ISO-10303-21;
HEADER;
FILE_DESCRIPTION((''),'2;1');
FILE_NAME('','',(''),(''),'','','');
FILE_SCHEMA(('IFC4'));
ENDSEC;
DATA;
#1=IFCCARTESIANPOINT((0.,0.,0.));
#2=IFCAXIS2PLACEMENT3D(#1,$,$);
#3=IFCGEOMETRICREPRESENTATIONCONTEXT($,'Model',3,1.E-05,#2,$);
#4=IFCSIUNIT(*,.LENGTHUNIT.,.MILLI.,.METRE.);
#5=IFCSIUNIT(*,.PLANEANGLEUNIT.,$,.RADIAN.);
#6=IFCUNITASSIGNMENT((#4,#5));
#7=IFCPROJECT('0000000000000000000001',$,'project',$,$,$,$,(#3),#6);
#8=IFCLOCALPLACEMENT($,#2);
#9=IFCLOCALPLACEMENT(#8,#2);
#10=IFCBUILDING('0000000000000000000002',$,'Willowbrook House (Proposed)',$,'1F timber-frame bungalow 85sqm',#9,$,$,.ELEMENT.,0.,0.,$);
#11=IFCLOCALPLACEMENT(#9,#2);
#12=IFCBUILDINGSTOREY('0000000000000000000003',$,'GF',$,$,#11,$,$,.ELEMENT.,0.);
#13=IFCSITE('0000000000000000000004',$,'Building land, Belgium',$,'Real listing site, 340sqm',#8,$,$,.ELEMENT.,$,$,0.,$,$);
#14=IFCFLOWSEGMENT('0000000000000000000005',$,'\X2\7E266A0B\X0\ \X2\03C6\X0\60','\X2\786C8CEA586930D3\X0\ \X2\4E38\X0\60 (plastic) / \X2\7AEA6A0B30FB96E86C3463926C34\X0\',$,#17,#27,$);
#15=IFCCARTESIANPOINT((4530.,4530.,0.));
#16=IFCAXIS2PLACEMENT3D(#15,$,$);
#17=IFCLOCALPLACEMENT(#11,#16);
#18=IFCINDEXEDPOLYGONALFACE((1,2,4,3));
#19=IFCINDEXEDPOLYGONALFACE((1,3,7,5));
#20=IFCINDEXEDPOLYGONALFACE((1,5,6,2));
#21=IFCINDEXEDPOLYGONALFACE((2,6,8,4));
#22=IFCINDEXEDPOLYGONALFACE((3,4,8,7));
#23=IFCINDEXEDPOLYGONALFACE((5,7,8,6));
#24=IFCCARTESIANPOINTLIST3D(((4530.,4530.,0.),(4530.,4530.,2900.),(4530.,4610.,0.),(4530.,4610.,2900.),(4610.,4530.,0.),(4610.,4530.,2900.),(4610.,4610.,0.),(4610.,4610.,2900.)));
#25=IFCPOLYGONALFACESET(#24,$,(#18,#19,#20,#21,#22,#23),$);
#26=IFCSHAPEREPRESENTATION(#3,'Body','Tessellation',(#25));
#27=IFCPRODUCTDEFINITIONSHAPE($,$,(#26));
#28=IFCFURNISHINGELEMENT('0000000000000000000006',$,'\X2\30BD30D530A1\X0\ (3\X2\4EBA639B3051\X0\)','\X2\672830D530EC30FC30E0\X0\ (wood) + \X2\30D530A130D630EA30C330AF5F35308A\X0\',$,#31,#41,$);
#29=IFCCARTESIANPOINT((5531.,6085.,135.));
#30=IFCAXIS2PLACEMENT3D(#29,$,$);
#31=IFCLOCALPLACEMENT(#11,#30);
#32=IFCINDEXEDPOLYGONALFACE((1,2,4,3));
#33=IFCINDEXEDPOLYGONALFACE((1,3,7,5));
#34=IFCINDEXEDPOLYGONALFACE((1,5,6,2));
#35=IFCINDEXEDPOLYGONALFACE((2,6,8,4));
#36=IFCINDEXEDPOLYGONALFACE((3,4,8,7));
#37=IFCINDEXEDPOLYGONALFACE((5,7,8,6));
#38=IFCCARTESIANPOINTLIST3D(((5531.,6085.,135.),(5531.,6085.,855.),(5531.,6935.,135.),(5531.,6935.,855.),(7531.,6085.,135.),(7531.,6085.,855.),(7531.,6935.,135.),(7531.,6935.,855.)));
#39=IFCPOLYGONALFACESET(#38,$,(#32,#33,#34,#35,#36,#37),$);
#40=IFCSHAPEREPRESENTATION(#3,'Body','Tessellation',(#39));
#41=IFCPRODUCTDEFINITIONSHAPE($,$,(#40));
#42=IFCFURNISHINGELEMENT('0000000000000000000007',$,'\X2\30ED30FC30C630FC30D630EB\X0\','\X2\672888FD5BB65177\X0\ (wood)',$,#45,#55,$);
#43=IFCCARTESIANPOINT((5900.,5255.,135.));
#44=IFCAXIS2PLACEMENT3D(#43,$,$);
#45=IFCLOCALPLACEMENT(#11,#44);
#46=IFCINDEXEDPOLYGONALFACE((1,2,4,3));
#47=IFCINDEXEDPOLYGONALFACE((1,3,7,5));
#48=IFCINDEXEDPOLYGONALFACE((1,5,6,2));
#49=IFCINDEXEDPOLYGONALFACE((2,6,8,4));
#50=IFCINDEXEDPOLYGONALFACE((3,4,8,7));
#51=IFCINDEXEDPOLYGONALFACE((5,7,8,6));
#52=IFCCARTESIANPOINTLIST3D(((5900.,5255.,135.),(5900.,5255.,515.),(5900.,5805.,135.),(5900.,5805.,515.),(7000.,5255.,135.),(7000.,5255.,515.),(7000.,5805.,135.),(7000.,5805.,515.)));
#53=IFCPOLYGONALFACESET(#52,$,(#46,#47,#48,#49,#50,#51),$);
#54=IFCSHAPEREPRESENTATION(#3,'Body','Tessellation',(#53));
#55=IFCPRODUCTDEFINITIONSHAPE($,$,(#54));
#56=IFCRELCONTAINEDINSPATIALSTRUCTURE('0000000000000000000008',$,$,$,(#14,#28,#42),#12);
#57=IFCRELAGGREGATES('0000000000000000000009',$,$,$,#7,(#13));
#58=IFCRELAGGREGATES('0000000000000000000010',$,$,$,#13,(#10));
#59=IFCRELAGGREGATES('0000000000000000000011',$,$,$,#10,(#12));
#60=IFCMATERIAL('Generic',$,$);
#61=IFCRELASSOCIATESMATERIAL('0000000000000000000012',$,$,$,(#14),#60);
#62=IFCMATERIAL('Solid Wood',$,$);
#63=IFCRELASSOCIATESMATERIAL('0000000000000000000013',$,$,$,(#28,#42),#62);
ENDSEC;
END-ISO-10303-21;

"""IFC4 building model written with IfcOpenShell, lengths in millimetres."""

from ifc_helpers import new_model, si_unit, frame, frame_2d, origin, place, context, project, spatial, rectangle, extrude, material, element, save


model = new_model("IFC4")

# Units and contexts
model_context = context("Model", 3, precision=1e-05, world=origin())
ifc_project = project(units=[si_unit("LENGTHUNIT", "METRE", prefix="MILLI"), si_unit("PLANEANGLEUNIT", "RADIAN")], contexts=[model_context])

# Site, building, storey
site_placement = place(None, origin())
site = spatial("IfcSite", under=ifc_project, at=site_placement, Name="Building land, Belgium", ObjectType="Real listing site, 340sqm", CompositionType="ELEMENT", RefElevation=0.0)
building_placement = place(site_placement, origin())
building = spatial("IfcBuilding", under=site, at=building_placement, Name="Willowbrook House (Proposed)", ObjectType="1F timber-frame bungalow 85sqm", CompositionType="ELEMENT", ElevationOfRefHeight=0.0, ElevationOfTerrain=0.0)
storey_placement = place(building_placement, origin())
storey = spatial("IfcBuildingStorey", under=building, at=storey_placement, Name="GF", CompositionType="ELEMENT", Elevation=0.0)

# Shared definitions
ifc_material_1 = material(Name="Solid Wood")

# Shared definitions
ifc_material_2 = material(Name="Generic")

# Flow segment
flow_segment_1_placement = place(storey_placement, frame((4530.0, 4530.0, 0.0)))
element("IfcFlowSegment", 1, at=flow_segment_1_placement, inside=storey, material=ifc_material_2, Name="縦樋 φ60", Description="硬質塩ビ 丸60 (plastic) / 竪樋・雨水排水", context=model_context, shape_type="SweptSolid", body=[
    extrude(rectangle(XDim=80.0, YDim=80.0, at=frame_2d((40.0, 40.0))), frame((4530.0, 4530.0, 0.0)), (0.0, 0.0, 1.0), 2900.0),
])

# Furnishing elements
furnishing_1_placement = place(storey_placement, frame((5531.0, 6085.0, 135.0)))
element("IfcFurnishingElement", 2, at=furnishing_1_placement, inside=storey, material=ifc_material_1, Name="ソファ (3人掛け)", Description="木フレーム (wood) + ファブリック張り", context=model_context, shape_type="SweptSolid", body=[
    extrude(rectangle(XDim=2000.0, YDim=850.0, at=frame_2d((1000.0, 425.0))), frame((5531.0, 6085.0, 135.0)), (0.0, 0.0, 1.0), 720.0),
])
furnishing_2_placement = place(storey_placement, frame((5900.0, 5255.0, 135.0)))
element("IfcFurnishingElement", 3, at=furnishing_2_placement, inside=storey, material=ifc_material_1, Name="ローテーブル", Description="木製家具 (wood)", context=model_context, shape_type="SweptSolid", body=[
    extrude(rectangle(XDim=1100.0, YDim=550.0, at=frame_2d((550.0, 275.0))), frame((5900.0, 5255.0, 135.0)), (0.0, 0.0, 1.0), 380.0),
])

save(model, "model.ifc")
